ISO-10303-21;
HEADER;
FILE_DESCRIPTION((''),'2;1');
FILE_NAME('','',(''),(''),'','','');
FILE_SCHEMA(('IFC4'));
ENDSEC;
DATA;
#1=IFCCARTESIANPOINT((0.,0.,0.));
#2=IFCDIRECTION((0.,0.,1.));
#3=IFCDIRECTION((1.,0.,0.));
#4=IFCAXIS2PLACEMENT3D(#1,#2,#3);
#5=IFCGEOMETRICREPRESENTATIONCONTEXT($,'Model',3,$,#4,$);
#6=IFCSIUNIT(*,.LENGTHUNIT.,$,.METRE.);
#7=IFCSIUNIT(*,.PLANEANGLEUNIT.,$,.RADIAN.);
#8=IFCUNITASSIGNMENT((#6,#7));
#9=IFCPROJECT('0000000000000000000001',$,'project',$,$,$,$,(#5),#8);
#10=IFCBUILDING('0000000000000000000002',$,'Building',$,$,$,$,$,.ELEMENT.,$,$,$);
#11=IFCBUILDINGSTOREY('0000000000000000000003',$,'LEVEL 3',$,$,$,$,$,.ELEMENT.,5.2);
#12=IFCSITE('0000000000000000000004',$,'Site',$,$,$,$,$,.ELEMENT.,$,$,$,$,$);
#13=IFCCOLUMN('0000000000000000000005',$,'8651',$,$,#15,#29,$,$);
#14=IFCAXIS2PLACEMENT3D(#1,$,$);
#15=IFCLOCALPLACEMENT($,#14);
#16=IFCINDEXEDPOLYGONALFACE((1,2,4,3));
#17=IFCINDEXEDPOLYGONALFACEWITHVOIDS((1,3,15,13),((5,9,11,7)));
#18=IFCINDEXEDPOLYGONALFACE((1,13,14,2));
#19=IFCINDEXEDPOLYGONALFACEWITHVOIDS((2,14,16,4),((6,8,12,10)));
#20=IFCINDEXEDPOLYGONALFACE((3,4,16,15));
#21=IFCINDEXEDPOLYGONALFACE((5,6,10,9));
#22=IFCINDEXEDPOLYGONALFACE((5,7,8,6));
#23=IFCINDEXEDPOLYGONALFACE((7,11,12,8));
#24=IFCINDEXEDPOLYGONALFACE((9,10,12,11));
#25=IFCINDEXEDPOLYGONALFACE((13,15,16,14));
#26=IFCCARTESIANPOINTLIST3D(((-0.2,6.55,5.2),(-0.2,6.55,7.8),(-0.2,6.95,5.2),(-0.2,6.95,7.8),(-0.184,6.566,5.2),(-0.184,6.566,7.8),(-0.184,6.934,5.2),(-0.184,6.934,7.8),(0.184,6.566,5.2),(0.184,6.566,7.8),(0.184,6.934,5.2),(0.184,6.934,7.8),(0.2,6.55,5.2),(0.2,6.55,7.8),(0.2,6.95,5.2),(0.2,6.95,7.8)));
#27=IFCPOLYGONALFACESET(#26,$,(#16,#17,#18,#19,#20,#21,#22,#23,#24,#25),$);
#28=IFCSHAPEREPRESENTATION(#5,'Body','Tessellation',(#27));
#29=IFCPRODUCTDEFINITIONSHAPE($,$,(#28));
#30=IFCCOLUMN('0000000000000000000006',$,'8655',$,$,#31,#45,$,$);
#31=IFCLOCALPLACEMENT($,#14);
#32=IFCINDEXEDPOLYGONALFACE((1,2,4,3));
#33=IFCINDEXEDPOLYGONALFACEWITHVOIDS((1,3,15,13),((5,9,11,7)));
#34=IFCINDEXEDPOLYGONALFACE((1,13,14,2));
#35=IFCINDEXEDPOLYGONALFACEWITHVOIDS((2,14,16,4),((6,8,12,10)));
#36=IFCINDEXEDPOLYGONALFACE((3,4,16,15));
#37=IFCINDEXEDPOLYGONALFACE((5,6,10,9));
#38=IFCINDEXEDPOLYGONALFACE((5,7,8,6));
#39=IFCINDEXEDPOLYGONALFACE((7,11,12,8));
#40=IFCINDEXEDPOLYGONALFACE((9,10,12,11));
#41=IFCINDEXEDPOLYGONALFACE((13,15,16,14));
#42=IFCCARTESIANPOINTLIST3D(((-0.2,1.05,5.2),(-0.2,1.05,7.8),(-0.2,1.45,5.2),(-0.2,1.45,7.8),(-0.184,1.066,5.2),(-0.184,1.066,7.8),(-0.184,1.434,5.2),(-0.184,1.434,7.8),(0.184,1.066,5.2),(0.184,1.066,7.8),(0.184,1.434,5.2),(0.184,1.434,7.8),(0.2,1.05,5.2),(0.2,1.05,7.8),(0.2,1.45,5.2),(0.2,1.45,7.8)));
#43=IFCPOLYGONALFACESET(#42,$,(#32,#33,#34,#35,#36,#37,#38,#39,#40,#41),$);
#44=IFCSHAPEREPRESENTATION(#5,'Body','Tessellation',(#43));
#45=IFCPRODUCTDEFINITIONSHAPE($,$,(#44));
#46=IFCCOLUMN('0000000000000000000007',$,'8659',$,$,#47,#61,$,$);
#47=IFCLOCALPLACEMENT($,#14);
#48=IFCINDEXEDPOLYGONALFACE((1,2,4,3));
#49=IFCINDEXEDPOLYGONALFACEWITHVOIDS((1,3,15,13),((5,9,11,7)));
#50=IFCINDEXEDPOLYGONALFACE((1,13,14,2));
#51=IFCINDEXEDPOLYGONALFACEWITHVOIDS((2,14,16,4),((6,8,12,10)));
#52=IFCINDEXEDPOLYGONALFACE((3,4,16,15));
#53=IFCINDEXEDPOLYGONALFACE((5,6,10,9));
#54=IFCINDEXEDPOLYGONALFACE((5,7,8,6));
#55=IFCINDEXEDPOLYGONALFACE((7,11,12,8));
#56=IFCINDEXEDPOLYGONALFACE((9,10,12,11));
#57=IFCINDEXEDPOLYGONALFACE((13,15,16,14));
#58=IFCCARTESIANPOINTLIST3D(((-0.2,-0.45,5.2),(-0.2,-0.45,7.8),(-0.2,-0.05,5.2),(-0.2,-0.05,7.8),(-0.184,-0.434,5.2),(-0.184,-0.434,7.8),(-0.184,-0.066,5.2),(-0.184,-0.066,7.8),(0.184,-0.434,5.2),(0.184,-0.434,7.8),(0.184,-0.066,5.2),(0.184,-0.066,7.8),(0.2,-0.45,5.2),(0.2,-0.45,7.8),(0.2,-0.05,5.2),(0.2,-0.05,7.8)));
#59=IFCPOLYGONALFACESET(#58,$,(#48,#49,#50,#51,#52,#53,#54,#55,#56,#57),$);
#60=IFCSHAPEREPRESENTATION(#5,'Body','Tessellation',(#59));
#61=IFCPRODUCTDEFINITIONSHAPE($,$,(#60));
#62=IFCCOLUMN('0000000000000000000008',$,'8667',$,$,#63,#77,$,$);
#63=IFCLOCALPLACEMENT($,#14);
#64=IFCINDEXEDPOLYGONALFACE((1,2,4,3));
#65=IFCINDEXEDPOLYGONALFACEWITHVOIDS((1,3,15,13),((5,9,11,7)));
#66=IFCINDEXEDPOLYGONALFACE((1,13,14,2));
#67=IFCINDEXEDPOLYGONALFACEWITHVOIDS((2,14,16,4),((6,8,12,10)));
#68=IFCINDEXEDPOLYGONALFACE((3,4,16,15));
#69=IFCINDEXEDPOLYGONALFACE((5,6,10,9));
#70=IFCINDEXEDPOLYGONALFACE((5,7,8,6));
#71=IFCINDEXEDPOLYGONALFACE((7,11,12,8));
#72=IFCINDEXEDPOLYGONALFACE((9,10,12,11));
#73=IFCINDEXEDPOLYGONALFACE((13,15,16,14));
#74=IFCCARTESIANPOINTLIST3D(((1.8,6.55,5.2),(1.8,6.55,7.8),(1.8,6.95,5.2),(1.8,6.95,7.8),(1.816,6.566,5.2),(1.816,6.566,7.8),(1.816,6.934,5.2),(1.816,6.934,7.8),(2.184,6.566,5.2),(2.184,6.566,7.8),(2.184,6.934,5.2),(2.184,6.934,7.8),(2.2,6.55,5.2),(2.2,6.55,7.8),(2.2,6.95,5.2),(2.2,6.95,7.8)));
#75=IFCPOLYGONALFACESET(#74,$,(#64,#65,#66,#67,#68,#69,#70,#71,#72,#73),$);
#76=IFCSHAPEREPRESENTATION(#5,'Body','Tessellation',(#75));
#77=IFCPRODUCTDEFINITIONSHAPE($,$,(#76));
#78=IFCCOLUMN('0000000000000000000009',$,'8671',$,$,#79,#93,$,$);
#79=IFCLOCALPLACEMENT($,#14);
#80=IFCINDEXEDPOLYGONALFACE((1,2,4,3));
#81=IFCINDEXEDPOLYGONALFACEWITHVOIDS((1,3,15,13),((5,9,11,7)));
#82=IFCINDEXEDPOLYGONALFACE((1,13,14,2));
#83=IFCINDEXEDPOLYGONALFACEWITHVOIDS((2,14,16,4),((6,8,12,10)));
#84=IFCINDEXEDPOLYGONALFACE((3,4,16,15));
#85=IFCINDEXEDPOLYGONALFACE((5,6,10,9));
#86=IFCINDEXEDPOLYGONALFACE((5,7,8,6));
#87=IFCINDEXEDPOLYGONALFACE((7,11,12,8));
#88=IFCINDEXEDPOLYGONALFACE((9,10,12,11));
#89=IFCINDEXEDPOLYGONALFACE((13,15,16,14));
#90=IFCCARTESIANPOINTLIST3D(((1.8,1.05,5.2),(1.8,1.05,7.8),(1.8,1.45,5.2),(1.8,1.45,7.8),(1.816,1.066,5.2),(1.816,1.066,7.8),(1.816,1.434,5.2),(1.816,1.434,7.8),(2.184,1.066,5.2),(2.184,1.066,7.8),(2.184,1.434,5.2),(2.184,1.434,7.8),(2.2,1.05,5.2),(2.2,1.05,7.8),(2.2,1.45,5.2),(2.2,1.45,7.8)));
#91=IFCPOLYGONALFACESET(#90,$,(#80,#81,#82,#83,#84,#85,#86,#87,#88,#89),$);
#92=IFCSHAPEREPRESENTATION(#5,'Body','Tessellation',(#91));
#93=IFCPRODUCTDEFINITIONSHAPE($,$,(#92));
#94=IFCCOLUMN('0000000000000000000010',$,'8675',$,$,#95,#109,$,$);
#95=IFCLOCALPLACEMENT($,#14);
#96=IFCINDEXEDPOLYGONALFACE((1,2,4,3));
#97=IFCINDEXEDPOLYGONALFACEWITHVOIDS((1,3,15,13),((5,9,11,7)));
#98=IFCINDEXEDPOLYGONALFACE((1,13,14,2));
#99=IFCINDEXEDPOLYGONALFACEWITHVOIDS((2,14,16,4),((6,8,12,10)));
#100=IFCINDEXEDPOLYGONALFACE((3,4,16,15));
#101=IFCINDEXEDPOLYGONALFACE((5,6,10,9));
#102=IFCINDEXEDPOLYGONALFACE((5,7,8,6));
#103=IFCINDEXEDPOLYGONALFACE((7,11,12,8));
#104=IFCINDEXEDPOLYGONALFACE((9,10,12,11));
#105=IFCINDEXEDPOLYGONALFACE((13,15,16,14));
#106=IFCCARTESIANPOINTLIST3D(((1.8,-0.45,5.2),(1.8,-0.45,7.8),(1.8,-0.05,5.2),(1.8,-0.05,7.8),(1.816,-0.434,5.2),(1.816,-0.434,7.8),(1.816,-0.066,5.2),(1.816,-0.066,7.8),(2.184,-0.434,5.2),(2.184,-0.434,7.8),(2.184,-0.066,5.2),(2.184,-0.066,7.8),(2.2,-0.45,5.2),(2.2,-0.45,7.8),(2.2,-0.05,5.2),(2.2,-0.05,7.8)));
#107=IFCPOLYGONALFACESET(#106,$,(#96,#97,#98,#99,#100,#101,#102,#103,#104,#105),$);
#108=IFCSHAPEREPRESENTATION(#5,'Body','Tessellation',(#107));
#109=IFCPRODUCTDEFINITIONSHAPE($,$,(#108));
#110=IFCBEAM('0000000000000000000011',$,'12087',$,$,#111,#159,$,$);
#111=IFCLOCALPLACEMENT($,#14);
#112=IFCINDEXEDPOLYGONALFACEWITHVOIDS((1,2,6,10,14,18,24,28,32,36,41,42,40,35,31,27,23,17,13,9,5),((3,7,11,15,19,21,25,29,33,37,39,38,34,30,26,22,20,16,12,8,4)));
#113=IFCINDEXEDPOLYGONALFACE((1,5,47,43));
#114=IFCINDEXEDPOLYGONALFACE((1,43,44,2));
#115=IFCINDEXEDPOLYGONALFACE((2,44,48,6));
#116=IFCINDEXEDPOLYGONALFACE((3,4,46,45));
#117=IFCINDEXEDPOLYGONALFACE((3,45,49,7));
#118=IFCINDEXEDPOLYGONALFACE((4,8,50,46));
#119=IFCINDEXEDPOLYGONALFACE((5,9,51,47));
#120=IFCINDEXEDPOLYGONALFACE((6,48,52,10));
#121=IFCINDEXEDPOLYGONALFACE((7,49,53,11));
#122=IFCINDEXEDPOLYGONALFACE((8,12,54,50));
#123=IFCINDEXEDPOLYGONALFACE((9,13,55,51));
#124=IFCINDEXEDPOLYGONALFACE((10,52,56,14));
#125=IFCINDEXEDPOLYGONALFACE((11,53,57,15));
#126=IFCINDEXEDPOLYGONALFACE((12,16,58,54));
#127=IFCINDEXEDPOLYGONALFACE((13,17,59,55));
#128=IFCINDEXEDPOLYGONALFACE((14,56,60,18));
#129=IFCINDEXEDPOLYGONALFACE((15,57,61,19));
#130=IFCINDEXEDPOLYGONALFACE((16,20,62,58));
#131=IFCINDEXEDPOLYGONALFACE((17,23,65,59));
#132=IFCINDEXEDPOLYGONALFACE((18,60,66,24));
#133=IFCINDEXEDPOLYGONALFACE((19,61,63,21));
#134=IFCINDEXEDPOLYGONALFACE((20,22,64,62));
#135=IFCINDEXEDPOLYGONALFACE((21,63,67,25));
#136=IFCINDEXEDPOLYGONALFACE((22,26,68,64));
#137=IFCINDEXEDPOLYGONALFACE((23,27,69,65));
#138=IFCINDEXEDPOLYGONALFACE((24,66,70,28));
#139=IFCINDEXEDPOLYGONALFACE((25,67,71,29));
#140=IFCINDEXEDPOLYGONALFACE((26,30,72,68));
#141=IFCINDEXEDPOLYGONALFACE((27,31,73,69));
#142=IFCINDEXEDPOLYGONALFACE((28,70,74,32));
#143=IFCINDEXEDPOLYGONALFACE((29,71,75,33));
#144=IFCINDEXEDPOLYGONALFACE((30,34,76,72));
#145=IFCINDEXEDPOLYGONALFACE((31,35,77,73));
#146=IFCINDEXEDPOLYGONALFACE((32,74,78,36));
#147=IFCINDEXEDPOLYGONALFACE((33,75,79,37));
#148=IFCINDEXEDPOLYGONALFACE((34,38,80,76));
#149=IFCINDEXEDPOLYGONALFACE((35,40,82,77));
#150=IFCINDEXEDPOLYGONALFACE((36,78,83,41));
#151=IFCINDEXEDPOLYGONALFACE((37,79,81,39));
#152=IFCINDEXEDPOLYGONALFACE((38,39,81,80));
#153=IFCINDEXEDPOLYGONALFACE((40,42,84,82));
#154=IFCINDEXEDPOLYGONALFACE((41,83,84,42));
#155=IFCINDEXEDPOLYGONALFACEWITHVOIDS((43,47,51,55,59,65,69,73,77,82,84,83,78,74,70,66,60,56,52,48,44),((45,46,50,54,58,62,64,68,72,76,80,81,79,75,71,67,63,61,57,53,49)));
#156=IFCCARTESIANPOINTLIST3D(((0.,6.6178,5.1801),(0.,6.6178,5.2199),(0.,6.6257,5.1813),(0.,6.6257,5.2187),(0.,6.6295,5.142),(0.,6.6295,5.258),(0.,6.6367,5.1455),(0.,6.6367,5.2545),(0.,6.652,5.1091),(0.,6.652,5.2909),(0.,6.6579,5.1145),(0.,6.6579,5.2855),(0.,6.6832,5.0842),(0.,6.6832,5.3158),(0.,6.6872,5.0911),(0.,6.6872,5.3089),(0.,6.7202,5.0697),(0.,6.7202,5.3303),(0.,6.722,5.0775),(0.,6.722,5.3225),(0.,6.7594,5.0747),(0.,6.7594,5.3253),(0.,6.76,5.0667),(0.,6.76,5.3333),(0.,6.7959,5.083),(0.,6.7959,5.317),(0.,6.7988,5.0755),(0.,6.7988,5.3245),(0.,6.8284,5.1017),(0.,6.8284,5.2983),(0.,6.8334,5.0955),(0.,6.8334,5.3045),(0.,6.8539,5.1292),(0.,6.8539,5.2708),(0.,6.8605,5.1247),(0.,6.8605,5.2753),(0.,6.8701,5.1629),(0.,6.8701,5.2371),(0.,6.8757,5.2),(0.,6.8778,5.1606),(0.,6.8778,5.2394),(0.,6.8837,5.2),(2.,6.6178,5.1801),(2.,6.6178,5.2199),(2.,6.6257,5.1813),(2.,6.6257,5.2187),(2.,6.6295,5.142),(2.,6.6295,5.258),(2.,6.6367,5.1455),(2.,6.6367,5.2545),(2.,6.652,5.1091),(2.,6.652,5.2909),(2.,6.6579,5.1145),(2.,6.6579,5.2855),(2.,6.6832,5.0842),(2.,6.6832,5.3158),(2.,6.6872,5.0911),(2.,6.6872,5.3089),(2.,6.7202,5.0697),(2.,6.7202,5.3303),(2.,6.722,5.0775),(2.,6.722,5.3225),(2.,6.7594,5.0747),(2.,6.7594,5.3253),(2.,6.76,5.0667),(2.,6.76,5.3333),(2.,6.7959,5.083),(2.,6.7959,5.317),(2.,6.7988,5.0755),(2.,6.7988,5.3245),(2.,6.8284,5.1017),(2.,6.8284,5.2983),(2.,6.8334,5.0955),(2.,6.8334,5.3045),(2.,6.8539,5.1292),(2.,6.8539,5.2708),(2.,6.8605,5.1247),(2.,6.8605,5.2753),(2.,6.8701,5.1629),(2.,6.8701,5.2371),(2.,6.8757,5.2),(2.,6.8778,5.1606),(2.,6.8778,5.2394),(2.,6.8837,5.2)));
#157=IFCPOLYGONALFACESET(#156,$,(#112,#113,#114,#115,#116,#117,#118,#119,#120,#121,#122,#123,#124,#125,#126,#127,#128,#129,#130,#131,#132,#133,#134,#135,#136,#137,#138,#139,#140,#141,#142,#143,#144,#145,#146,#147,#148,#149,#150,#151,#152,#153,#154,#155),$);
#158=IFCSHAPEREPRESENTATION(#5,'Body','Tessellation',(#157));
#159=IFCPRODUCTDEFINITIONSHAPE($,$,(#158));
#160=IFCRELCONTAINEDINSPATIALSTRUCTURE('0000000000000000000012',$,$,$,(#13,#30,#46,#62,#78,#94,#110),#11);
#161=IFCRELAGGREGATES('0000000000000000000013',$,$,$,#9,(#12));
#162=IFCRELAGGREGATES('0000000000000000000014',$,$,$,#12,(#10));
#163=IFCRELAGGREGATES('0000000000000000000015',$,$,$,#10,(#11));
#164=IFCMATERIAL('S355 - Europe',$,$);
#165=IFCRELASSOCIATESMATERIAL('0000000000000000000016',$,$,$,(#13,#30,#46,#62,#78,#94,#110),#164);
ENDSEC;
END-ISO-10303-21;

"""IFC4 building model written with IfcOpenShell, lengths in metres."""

from ifc_helpers import new_model, si_unit, frame, origin_with_axes, origin_2d_with_axis, place, context, project, spatial, hollow_rectangle, hollow_circle, extrude, material, material_profile, profile_set, profile_usage, element, save


model = new_model("IFC4")

# Units and contexts
model_context = context("Model", 3, world=origin_with_axes())
ifc_project = project(units=[si_unit("LENGTHUNIT", "METRE"), si_unit("PLANEANGLEUNIT", "RADIAN")], contexts=[model_context])

# Site, building, storey
site = spatial("IfcSite", under=ifc_project, Name="Site", CompositionType="ELEMENT")
building = spatial("IfcBuilding", under=site, Name="Building", CompositionType="ELEMENT")
storey = spatial("IfcBuildingStorey", under=building, Name="LEVEL 3", CompositionType="ELEMENT", Elevation=5.2)

# Columns
ifc_material = material(Name="S355 - Europe")
ifc_material_profile_1 = material_profile(ifc_material, hollow_rectangle(XDim=0.4, YDim=0.4, WallThickness=0.016, at=origin_2d_with_axis()))
ifc_profile_set_1 = profile_set([ifc_material_profile_1])
ifc_profile_usage_1 = profile_usage(ifc_profile_set_1, cardinal=10)
column_1_placement = place(None, frame((0.0, 6.75, 5.2), z_axis=(0.0, 0.0, 1.0), x_axis=(0.0, -1.0, 0.0)))
element("IfcColumn", 1, at=column_1_placement, inside=storey, material=ifc_profile_usage_1, Name="8651", context=model_context, shape_type="SweptSolid", body=[
    extrude(hollow_rectangle(XDim=0.4, YDim=0.4, WallThickness=0.016, at=origin_2d_with_axis()), origin_with_axes(), (0.0, 0.0, 1.0), 2.6),
])
ifc_material_profile_2 = material_profile(ifc_material, hollow_rectangle(XDim=0.4, YDim=0.4, WallThickness=0.016, at=origin_2d_with_axis()))
ifc_profile_set_2 = profile_set([ifc_material_profile_2])
ifc_profile_usage_2 = profile_usage(ifc_profile_set_2, cardinal=10)
column_2_placement = place(None, frame((0.0, 1.25, 5.2), z_axis=(0.0, 0.0, 1.0), x_axis=(0.0, -1.0, 0.0)))
element("IfcColumn", 2, at=column_2_placement, inside=storey, material=ifc_profile_usage_2, Name="8655", context=model_context, shape_type="SweptSolid", body=[
    extrude(hollow_rectangle(XDim=0.4, YDim=0.4, WallThickness=0.016, at=origin_2d_with_axis()), origin_with_axes(), (0.0, 0.0, 1.0), 2.6),
])
ifc_material_profile_3 = material_profile(ifc_material, hollow_rectangle(XDim=0.4, YDim=0.4, WallThickness=0.016, at=origin_2d_with_axis()))
ifc_profile_set_3 = profile_set([ifc_material_profile_3])
ifc_profile_usage_3 = profile_usage(ifc_profile_set_3, cardinal=10)
column_3_placement = place(None, frame((0.0, -0.25, 5.2), z_axis=(0.0, 0.0, 1.0), x_axis=(0.0, -1.0, 0.0)))
element("IfcColumn", 3, at=column_3_placement, inside=storey, material=ifc_profile_usage_3, Name="8659", context=model_context, shape_type="SweptSolid", body=[
    extrude(hollow_rectangle(XDim=0.4, YDim=0.4, WallThickness=0.016, at=origin_2d_with_axis()), origin_with_axes(), (0.0, 0.0, 1.0), 2.6),
])
ifc_material_profile_4 = material_profile(ifc_material, hollow_rectangle(XDim=0.4, YDim=0.4, WallThickness=0.016, at=origin_2d_with_axis()))
ifc_profile_set_4 = profile_set([ifc_material_profile_4])
ifc_profile_usage_4 = profile_usage(ifc_profile_set_4, cardinal=10)
column_4_placement = place(None, frame((2.0, 6.75, 5.2), z_axis=(0.0, 0.0, 1.0), x_axis=(0.0, -1.0, 0.0)))
element("IfcColumn", 4, at=column_4_placement, inside=storey, material=ifc_profile_usage_4, Name="8667", context=model_context, shape_type="SweptSolid", body=[
    extrude(hollow_rectangle(XDim=0.4, YDim=0.4, WallThickness=0.016, at=origin_2d_with_axis()), origin_with_axes(), (0.0, 0.0, 1.0), 2.6),
])
ifc_material_profile_5 = material_profile(ifc_material, hollow_rectangle(XDim=0.4, YDim=0.4, WallThickness=0.016, at=origin_2d_with_axis()))
ifc_profile_set_5 = profile_set([ifc_material_profile_5])
ifc_profile_usage_5 = profile_usage(ifc_profile_set_5, cardinal=10)
column_5_placement = place(None, frame((2.0, 1.25, 5.2), z_axis=(0.0, 0.0, 1.0), x_axis=(0.0, -1.0, 0.0)))
element("IfcColumn", 5, at=column_5_placement, inside=storey, material=ifc_profile_usage_5, Name="8671", context=model_context, shape_type="SweptSolid", body=[
    extrude(hollow_rectangle(XDim=0.4, YDim=0.4, WallThickness=0.016, at=origin_2d_with_axis()), origin_with_axes(), (0.0, 0.0, 1.0), 2.6),
])
ifc_material_profile_6 = material_profile(ifc_material, hollow_rectangle(XDim=0.4, YDim=0.4, WallThickness=0.016, at=origin_2d_with_axis()))
ifc_profile_set_6 = profile_set([ifc_material_profile_6])
ifc_profile_usage_6 = profile_usage(ifc_profile_set_6, cardinal=10)
column_6_placement = place(None, frame((2.0, -0.25, 5.2), z_axis=(0.0, 0.0, 1.0), x_axis=(0.0, -1.0, 0.0)))
element("IfcColumn", 6, at=column_6_placement, inside=storey, material=ifc_profile_usage_6, Name="8675", context=model_context, shape_type="SweptSolid", body=[
    extrude(hollow_rectangle(XDim=0.4, YDim=0.4, WallThickness=0.016, at=origin_2d_with_axis()), origin_with_axes(), (0.0, 0.0, 1.0), 2.6),
])

# Beam
ifc_material_profile_7 = material_profile(ifc_material, hollow_circle(Radius=0.1337, WallThickness=0.008, at=origin_2d_with_axis()))
ifc_profile_set_7 = profile_set([ifc_material_profile_7])
ifc_profile_usage_7 = profile_usage(ifc_profile_set_7, cardinal=10)
beam_1_placement = place(None, frame((0.0, 6.75, 5.2), z_axis=(1.0, 0.0, 0.0), x_axis=(0.0, 1.0, 0.0)))
element("IfcBeam", 7, at=beam_1_placement, inside=storey, material=ifc_profile_usage_7, Name="12087", context=model_context, shape_type="SweptSolid", body=[
    extrude(hollow_circle(Radius=0.1337, WallThickness=0.008, at=origin_2d_with_axis()), origin_with_axes(), (0.0, 0.0, 1.0), 2.0),
])

save(model, "model.ifc")
